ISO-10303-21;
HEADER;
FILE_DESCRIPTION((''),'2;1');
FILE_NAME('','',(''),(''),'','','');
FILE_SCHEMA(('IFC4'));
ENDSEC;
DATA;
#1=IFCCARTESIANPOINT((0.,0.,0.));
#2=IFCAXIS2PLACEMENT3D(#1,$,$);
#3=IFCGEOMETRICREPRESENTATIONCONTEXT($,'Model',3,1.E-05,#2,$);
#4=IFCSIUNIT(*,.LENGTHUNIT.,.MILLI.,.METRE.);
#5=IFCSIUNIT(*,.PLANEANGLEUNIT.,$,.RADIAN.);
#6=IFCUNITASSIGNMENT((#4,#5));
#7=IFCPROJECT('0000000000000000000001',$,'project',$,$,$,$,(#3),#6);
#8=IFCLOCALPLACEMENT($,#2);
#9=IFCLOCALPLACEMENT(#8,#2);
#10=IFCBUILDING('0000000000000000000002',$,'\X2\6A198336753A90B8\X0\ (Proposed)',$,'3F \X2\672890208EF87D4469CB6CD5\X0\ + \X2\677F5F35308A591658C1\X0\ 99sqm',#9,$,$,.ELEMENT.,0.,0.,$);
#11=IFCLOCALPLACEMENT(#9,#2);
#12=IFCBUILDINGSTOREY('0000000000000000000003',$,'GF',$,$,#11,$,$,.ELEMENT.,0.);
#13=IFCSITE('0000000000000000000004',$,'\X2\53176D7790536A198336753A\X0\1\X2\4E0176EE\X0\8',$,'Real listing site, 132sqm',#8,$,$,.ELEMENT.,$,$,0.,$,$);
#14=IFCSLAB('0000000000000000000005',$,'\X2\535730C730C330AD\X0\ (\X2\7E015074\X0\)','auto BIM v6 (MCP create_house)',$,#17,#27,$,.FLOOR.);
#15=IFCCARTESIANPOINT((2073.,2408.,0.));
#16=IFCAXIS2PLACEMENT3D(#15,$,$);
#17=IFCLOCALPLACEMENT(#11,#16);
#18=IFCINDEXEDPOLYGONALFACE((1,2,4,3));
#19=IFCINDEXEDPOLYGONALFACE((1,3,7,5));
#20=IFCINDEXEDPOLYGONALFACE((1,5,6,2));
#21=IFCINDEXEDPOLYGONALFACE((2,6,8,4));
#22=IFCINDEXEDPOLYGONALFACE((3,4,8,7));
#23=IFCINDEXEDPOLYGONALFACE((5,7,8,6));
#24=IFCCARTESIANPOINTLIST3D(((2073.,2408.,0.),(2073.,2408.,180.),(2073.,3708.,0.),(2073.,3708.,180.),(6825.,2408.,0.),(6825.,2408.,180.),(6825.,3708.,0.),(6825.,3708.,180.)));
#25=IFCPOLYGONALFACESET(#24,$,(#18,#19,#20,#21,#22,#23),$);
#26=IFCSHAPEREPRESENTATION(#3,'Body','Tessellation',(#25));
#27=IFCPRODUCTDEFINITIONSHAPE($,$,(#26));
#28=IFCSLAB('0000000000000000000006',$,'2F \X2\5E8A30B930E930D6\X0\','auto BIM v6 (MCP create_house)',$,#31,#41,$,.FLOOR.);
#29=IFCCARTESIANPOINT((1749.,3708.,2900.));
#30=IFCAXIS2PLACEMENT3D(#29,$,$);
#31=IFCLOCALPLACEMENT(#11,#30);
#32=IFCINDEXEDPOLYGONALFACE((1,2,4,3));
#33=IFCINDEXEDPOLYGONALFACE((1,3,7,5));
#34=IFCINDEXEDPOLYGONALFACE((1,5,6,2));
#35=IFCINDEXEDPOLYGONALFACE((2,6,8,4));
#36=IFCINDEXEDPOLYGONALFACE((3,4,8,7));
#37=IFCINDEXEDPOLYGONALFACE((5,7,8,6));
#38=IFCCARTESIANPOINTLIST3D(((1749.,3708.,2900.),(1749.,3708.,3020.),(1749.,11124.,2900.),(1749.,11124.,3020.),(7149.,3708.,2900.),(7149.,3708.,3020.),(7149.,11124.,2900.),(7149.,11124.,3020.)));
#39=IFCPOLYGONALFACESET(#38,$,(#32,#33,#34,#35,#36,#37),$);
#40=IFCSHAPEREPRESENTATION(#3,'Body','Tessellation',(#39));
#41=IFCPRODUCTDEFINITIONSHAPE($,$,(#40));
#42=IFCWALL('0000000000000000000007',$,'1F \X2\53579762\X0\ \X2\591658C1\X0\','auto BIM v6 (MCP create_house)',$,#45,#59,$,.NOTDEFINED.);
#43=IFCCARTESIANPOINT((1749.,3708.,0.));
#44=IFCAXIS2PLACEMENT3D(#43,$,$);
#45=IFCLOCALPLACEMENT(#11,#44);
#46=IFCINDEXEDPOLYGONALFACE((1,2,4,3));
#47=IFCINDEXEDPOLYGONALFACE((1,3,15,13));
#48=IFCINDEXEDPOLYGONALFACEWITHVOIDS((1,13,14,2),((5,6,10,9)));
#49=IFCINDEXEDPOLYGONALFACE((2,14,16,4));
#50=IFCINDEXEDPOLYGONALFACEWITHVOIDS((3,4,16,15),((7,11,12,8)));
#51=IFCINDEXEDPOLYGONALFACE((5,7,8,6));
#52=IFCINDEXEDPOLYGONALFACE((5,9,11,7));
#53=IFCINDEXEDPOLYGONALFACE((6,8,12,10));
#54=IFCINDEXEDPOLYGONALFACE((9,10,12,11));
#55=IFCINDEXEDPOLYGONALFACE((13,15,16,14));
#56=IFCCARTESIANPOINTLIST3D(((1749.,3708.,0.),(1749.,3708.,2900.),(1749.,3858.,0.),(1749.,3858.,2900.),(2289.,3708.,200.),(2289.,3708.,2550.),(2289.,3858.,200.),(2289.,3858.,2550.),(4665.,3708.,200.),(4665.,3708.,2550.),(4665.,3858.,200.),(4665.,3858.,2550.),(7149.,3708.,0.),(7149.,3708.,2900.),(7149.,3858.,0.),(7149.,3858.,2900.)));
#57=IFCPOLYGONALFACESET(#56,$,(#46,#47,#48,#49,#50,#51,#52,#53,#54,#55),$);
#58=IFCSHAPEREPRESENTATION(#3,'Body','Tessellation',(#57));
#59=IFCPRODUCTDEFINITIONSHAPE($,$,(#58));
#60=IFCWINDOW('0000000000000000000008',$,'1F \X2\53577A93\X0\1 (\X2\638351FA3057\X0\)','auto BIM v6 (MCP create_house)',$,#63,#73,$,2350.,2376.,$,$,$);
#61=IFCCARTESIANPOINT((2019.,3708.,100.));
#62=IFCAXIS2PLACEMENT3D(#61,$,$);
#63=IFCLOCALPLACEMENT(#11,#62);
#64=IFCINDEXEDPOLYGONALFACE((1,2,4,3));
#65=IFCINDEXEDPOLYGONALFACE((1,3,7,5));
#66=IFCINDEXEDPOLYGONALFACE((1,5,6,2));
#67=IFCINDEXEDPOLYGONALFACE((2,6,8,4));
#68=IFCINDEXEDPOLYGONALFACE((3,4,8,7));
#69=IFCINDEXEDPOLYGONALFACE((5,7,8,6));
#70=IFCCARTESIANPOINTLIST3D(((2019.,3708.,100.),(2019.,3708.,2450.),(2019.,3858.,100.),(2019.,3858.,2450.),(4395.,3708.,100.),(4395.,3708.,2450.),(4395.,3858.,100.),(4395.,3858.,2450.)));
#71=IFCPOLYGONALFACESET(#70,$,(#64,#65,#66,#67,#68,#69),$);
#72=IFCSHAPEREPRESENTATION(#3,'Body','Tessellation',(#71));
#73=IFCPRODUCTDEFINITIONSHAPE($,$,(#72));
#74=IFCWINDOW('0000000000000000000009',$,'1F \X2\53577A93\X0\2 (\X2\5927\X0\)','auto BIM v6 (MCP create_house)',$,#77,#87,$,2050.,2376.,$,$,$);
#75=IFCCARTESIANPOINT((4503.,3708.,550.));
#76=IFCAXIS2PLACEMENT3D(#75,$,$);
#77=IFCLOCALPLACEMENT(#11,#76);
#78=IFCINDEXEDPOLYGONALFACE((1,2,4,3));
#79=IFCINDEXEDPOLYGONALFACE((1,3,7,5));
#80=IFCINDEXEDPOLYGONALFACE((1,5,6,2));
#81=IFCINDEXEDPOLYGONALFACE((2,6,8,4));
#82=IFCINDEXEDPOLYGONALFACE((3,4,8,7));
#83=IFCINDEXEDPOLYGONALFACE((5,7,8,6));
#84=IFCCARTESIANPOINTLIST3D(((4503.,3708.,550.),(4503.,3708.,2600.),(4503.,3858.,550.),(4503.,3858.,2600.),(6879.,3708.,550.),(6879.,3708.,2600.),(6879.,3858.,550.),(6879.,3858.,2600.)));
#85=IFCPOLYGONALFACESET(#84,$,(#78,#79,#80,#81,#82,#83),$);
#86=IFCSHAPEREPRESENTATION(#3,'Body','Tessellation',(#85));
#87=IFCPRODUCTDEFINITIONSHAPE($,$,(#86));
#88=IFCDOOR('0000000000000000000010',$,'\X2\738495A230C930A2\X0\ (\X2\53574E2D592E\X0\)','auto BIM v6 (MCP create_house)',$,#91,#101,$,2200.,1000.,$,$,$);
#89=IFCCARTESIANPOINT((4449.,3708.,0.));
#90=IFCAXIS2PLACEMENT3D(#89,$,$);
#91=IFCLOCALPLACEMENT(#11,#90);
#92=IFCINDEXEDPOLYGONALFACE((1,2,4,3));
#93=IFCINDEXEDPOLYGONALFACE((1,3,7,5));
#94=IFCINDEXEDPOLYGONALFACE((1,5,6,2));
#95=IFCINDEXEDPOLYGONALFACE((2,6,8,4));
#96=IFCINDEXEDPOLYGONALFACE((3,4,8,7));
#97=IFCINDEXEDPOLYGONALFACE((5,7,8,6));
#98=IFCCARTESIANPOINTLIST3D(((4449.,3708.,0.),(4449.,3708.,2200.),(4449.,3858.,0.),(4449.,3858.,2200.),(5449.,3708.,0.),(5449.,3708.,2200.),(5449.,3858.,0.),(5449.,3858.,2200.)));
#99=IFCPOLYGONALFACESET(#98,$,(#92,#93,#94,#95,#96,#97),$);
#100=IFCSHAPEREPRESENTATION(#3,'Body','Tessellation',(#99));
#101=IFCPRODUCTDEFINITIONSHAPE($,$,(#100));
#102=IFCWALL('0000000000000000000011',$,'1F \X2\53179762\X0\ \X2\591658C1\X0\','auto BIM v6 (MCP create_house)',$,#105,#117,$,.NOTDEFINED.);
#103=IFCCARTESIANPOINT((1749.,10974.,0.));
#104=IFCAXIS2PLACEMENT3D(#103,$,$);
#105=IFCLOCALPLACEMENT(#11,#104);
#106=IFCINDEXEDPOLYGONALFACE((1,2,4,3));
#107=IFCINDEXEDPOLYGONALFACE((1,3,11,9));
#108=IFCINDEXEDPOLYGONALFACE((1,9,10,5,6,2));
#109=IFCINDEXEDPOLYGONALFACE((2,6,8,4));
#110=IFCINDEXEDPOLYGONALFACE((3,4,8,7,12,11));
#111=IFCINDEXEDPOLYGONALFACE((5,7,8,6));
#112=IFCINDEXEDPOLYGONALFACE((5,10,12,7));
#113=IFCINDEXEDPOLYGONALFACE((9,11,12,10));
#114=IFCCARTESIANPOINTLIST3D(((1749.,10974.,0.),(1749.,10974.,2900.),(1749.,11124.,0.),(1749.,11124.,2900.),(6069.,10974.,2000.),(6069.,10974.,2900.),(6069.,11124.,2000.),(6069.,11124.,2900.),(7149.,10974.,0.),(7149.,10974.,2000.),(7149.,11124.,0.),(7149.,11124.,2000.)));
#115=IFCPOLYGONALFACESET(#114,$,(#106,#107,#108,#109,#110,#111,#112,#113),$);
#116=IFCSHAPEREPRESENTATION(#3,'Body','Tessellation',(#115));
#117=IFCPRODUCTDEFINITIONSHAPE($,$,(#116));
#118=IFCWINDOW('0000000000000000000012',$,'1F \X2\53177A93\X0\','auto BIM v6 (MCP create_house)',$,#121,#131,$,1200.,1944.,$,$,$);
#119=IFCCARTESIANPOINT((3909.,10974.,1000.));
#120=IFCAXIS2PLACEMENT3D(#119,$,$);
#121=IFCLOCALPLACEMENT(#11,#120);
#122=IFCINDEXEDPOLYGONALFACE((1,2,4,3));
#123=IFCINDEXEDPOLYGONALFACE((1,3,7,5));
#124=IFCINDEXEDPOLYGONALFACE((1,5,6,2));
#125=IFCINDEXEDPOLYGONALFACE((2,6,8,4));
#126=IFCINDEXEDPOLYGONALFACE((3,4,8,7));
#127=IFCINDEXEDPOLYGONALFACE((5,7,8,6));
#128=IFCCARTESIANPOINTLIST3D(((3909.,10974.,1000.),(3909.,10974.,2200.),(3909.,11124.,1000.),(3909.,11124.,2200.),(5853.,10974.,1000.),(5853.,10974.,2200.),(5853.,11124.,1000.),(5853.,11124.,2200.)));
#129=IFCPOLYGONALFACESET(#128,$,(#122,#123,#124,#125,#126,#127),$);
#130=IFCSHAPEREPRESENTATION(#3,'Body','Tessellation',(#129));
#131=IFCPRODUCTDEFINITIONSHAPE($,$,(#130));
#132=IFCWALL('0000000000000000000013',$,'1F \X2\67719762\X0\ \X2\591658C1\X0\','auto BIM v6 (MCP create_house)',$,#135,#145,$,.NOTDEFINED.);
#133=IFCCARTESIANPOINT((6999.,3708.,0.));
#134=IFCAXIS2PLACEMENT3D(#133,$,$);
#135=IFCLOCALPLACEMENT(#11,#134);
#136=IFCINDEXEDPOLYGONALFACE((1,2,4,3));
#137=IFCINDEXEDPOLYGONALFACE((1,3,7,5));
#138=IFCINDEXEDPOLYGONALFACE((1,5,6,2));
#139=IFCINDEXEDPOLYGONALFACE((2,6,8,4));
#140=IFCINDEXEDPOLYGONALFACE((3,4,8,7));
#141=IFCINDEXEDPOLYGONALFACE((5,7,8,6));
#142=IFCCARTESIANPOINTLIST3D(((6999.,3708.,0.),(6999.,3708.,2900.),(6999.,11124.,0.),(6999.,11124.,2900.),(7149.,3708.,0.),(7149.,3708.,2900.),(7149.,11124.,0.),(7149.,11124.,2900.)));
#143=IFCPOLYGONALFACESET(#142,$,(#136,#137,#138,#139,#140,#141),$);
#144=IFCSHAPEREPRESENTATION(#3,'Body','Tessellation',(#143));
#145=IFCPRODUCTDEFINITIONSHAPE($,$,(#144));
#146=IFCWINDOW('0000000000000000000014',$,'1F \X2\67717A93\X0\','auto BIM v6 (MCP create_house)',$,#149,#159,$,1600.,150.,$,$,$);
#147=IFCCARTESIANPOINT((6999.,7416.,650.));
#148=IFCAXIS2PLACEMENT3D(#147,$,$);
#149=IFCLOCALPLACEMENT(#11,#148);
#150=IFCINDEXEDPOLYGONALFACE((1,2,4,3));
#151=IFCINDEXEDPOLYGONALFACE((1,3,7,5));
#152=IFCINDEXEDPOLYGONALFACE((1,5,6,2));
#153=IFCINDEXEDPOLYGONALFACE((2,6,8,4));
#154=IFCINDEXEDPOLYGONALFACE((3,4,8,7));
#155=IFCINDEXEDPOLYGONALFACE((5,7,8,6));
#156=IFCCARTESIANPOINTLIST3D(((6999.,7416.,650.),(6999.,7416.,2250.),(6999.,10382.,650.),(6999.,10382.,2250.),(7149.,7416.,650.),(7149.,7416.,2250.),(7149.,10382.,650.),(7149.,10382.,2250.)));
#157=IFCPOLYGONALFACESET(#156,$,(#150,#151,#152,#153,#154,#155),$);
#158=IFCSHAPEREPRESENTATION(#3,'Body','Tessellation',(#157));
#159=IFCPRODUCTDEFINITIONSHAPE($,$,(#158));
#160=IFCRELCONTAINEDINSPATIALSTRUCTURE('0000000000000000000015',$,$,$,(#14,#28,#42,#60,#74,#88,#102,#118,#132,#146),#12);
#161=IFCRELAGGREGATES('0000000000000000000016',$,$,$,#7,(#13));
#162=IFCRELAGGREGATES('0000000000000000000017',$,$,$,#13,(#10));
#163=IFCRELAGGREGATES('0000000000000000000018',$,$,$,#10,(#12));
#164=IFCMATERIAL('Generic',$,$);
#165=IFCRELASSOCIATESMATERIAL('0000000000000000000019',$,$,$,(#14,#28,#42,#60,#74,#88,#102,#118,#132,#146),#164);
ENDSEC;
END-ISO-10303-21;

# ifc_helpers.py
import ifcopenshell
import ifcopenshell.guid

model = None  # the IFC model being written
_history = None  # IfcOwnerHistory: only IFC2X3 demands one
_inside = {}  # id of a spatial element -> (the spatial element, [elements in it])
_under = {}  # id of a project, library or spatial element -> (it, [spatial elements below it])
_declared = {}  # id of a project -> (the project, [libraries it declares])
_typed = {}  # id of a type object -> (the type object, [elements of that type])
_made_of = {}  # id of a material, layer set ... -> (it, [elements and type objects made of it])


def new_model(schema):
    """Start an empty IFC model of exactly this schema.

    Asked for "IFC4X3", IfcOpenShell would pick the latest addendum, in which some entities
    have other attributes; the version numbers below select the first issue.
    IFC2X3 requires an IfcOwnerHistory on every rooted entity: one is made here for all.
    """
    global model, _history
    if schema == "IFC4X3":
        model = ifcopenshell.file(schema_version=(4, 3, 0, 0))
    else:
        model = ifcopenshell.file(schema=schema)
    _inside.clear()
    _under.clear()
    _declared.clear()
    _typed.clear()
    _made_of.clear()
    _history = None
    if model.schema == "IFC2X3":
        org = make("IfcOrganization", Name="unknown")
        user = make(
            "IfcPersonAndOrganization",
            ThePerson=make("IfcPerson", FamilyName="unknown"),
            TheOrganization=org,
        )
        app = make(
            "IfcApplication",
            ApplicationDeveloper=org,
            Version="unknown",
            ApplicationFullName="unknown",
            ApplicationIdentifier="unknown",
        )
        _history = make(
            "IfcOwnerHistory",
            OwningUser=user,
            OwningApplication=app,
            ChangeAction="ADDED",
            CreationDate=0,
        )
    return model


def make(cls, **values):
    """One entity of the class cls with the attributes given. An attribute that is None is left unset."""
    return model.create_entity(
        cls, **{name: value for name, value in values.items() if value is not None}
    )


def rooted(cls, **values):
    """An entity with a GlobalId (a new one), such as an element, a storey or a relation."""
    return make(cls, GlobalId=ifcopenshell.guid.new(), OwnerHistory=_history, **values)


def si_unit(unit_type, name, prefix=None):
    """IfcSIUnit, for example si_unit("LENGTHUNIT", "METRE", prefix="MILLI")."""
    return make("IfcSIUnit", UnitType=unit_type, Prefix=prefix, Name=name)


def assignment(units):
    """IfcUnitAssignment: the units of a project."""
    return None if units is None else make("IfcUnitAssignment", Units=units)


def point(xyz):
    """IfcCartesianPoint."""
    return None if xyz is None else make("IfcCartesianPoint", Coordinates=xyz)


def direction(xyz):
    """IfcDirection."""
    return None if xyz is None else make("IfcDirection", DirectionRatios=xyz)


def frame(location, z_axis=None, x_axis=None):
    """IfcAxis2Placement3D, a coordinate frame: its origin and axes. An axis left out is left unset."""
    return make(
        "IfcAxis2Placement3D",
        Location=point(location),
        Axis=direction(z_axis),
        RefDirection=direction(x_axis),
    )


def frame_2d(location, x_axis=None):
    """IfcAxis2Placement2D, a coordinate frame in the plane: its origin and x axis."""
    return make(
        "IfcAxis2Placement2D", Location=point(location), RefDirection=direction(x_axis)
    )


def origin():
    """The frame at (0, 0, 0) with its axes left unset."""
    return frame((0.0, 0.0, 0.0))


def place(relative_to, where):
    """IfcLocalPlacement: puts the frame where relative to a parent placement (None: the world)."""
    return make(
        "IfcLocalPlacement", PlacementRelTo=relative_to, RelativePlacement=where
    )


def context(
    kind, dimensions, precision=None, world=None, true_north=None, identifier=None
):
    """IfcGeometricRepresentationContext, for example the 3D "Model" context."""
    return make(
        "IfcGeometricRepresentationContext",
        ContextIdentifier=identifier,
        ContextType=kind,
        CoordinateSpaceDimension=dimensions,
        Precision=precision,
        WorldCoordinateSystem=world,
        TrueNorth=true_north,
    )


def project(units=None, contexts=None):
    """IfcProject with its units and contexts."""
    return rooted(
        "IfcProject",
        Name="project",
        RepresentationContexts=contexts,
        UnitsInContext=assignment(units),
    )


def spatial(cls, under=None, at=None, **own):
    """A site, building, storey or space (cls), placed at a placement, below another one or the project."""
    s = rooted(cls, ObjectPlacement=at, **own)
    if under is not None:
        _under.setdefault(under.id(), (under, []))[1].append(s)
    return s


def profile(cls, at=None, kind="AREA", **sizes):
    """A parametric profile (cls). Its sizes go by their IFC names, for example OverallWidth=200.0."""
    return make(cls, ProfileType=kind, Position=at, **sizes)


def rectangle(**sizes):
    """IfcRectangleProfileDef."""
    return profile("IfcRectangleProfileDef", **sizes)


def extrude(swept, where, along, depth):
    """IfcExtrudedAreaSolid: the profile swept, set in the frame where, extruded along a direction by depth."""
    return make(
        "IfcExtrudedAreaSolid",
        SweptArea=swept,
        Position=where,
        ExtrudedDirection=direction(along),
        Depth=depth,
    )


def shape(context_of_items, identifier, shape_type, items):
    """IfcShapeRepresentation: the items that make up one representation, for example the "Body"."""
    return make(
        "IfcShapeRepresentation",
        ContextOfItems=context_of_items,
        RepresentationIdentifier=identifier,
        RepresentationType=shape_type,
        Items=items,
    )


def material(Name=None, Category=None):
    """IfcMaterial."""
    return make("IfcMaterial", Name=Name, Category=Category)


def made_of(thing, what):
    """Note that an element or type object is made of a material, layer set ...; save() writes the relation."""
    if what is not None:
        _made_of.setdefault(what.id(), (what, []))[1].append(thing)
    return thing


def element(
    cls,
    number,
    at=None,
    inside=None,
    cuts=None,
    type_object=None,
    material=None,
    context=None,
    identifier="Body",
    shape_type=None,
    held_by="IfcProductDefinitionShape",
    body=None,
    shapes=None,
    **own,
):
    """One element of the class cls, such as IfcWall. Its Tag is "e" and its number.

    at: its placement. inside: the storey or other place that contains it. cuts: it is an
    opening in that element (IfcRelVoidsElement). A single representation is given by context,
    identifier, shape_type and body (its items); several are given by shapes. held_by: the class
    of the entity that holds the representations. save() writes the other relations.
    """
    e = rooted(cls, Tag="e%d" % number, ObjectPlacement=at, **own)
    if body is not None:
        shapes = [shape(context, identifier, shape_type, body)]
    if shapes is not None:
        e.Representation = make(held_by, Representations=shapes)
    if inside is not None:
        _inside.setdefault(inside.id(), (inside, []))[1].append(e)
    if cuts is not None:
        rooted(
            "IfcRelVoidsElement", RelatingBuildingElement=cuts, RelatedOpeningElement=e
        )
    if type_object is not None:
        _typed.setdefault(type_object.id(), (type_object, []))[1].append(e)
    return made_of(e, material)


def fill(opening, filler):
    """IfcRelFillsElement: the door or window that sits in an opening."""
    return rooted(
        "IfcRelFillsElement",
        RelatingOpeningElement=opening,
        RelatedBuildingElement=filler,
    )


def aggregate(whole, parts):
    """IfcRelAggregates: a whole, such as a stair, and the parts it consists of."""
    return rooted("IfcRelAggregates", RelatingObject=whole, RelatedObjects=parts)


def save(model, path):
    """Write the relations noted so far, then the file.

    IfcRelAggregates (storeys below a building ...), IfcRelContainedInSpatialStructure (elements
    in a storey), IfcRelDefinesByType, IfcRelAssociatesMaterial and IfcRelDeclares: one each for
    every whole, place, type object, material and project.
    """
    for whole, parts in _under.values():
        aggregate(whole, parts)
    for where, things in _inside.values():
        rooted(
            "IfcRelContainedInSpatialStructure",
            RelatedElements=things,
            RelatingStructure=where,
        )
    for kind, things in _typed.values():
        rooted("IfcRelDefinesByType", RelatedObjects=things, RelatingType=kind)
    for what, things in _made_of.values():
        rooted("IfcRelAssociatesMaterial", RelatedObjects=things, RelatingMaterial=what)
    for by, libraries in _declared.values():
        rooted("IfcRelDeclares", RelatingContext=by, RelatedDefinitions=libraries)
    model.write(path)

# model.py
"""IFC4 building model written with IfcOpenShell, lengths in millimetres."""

from ifc_helpers import new_model, si_unit, frame, frame_2d, origin, place, context, project, spatial, rectangle, extrude, material, element, fill, save


model = new_model("IFC4")

# Units and contexts
model_context = context("Model", 3, precision=1e-05, world=origin())
ifc_project = project(units=[si_unit("LENGTHUNIT", "METRE", prefix="MILLI"), si_unit("PLANEANGLEUNIT", "RADIAN")], contexts=[model_context])

# Site, building, storey
site_placement = place(None, origin())
site = spatial("IfcSite", under=ifc_project, at=site_placement, Name="北海道標茶町1丁目8", ObjectType="Real listing site, 132sqm", CompositionType="ELEMENT", RefElevation=0.0)
building_placement = place(site_placement, origin())
building = spatial("IfcBuilding", under=site, at=building_placement, Name="標茶町邸 (Proposed)", ObjectType="3F 木造軸組構法 + 板張り外壁 99sqm", CompositionType="ELEMENT", ElevationOfRefHeight=0.0, ElevationOfTerrain=0.0)
storey_placement = place(building_placement, origin())
storey = spatial("IfcBuildingStorey", under=building, at=storey_placement, Name="GF", CompositionType="ELEMENT", Elevation=0.0)

# Slabs
ifc_material = material(Name="Generic")
slab_1_placement = place(storey_placement, frame((2073.0, 2408.0, 0.0)))
element("IfcSlab", 1, at=slab_1_placement, inside=storey, material=ifc_material, Name="南デッキ (縁側)", Description="auto BIM v6 (MCP create_house)", PredefinedType="FLOOR", context=model_context, shape_type="SweptSolid", body=[
    extrude(rectangle(XDim=4752.0, YDim=1300.0, at=frame_2d((2376.0, 650.0))), frame((2073.0, 2408.0, 0.0)), (0.0, 0.0, 1.0), 180.0),
])
slab_2_placement = place(storey_placement, frame((1749.0, 3708.0, 2900.0)))
element("IfcSlab", 2, at=slab_2_placement, inside=storey, material=ifc_material, Name="2F 床スラブ", Description="auto BIM v6 (MCP create_house)", PredefinedType="FLOOR", context=model_context, shape_type="SweptSolid", body=[
    extrude(rectangle(XDim=5400.0, YDim=7416.0, at=frame_2d((2700.0, 3708.0))), frame((1749.0, 3708.0, 2900.0)), (0.0, 0.0, 1.0), 120.0),
])

# Wall, openings, windows, door
wall_1_placement = place(storey_placement, frame((1749.0, 3708.0, 0.0)))
wall_1 = element("IfcWall", 3, at=wall_1_placement, inside=storey, material=ifc_material, Name="1F 南面 外壁", Description="auto BIM v6 (MCP create_house)", PredefinedType="NOTDEFINED", context=model_context, shape_type="SweptSolid", body=[
    extrude(rectangle(XDim=5400.0, YDim=150.0, at=frame_2d((2700.0, 75.0))), frame((1749.0, 3708.0, 0.0)), (0.0, 0.0, 1.0), 2900.0),
])
opening_1_placement = place(storey_placement, frame((2019.0, 3708.0, 100.0)))
opening_1 = element("IfcOpeningElement", 4, at=opening_1_placement, cuts=wall_1, PredefinedType="NOTDEFINED", context=model_context, shape_type="SweptSolid", body=[
    extrude(rectangle(XDim=2376.0, YDim=150.0, at=frame_2d((1188.0, 75.0))), frame((2019.0, 3708.0, 100.0)), (0.0, 0.0, 1.0), 2350.0),
])
opening_2_placement = place(storey_placement, frame((4503.0, 3708.0, 550.0)))
opening_2 = element("IfcOpeningElement", 5, at=opening_2_placement, cuts=wall_1, PredefinedType="NOTDEFINED", context=model_context, shape_type="SweptSolid", body=[
    extrude(rectangle(XDim=2376.0, YDim=150.0, at=frame_2d((1188.0, 75.0))), frame((4503.0, 3708.0, 550.0)), (0.0, 0.0, 1.0), 2050.0),
])
opening_3_placement = place(storey_placement, frame((4449.0, 3708.0, 0.0)))
opening_3 = element("IfcOpeningElement", 6, at=opening_3_placement, cuts=wall_1, PredefinedType="NOTDEFINED", context=model_context, shape_type="SweptSolid", body=[
    extrude(rectangle(XDim=1000.0, YDim=150.0, at=frame_2d((500.0, 75.0))), frame((4449.0, 3708.0, 0.0)), (0.0, 0.0, 1.0), 2200.0),
])
window_1_placement = place(storey_placement, frame((2019.0, 3708.0, 100.0)))
window_1 = element("IfcWindow", 7, at=window_1_placement, inside=storey, material=ifc_material, Name="1F 南窓1 (掃出し)", Description="auto BIM v6 (MCP create_house)", OverallHeight=2350.0, OverallWidth=2376.0, context=model_context, shape_type="SweptSolid", body=[
    extrude(rectangle(XDim=2376.0, YDim=150.0, at=frame_2d((1188.0, 75.0))), frame((2019.0, 3708.0, 100.0)), (0.0, 0.0, 1.0), 2350.0),
])
fill(opening_1, window_1)
window_2_placement = place(storey_placement, frame((4503.0, 3708.0, 550.0)))
window_2 = element("IfcWindow", 8, at=window_2_placement, inside=storey, material=ifc_material, Name="1F 南窓2 (大)", Description="auto BIM v6 (MCP create_house)", OverallHeight=2050.0, OverallWidth=2376.0, context=model_context, shape_type="SweptSolid", body=[
    extrude(rectangle(XDim=2376.0, YDim=150.0, at=frame_2d((1188.0, 75.0))), frame((4503.0, 3708.0, 550.0)), (0.0, 0.0, 1.0), 2050.0),
])
fill(opening_2, window_2)
door_placement = place(storey_placement, frame((4449.0, 3708.0, 0.0)))
door = element("IfcDoor", 9, at=door_placement, inside=storey, material=ifc_material, Name="玄関ドア (南中央)", Description="auto BIM v6 (MCP create_house)", OverallHeight=2200.0, OverallWidth=1000.0, context=model_context, shape_type="SweptSolid", body=[
    extrude(rectangle(XDim=1000.0, YDim=150.0, at=frame_2d((500.0, 75.0))), frame((4449.0, 3708.0, 0.0)), (0.0, 0.0, 1.0), 2200.0),
])
fill(opening_3, door)

# Walls, openings, windows
wall_2_placement = place(storey_placement, frame((1749.0, 10974.0, 0.0)))
wall_2 = element("IfcWall", 10, at=wall_2_placement, inside=storey, material=ifc_material, Name="1F 北面 外壁", Description="auto BIM v6 (MCP create_house)", PredefinedType="NOTDEFINED", context=model_context, shape_type="SweptSolid", body=[
    extrude(rectangle(XDim=5400.0, YDim=150.0, at=frame_2d((2700.0, 75.0))), frame((1749.0, 10974.0, 0.0)), (0.0, 0.0, 1.0), 2900.0),
])
opening_4_placement = place(storey_placement, frame((3909.0, 10974.0, 1000.0)))
opening_4 = element("IfcOpeningElement", 11, at=opening_4_placement, cuts=wall_2, PredefinedType="NOTDEFINED", context=model_context, shape_type="SweptSolid", body=[
    extrude(rectangle(XDim=1944.0, YDim=150.0, at=frame_2d((972.0, 75.0))), frame((3909.0, 10974.0, 1000.0)), (0.0, 0.0, 1.0), 1200.0),
])
window_3_placement = place(storey_placement, frame((3909.0, 10974.0, 1000.0)))
window_3 = element("IfcWindow", 12, at=window_3_placement, inside=storey, material=ifc_material, Name="1F 北窓", Description="auto BIM v6 (MCP create_house)", OverallHeight=1200.0, OverallWidth=1944.0, context=model_context, shape_type="SweptSolid", body=[
    extrude(rectangle(XDim=1944.0, YDim=150.0, at=frame_2d((972.0, 75.0))), frame((3909.0, 10974.0, 1000.0)), (0.0, 0.0, 1.0), 1200.0),
])
fill(opening_4, window_3)
wall_3_placement = place(storey_placement, frame((6999.0, 3708.0, 0.0)))
wall_3 = element("IfcWall", 13, at=wall_3_placement, inside=storey, material=ifc_material, Name="1F 東面 外壁", Description="auto BIM v6 (MCP create_house)", PredefinedType="NOTDEFINED", context=model_context, shape_type="SweptSolid", body=[
    extrude(rectangle(XDim=150.0, YDim=7416.0, at=frame_2d((75.0, 3708.0))), frame((6999.0, 3708.0, 0.0)), (0.0, 0.0, 1.0), 2900.0),
])
opening_5_placement = place(storey_placement, frame((6999.0, 7416.0, 650.0)))
opening_5 = element("IfcOpeningElement", 14, at=opening_5_placement, cuts=wall_3, PredefinedType="NOTDEFINED", context=model_context, shape_type="SweptSolid", body=[
    extrude(rectangle(XDim=150.0, YDim=2966.0, at=frame_2d((75.0, 1483.0))), frame((6999.0, 7416.0, 650.0)), (0.0, 0.0, 1.0), 1600.0),
])
window_4_placement = place(storey_placement, frame((6999.0, 7416.0, 650.0)))
window_4 = element("IfcWindow", 15, at=window_4_placement, inside=storey, material=ifc_material, Name="1F 東窓", Description="auto BIM v6 (MCP create_house)", OverallHeight=1600.0, OverallWidth=150.0, context=model_context, shape_type="SweptSolid", body=[
    extrude(rectangle(XDim=150.0, YDim=2966.0, at=frame_2d((75.0, 1483.0))), frame((6999.0, 7416.0, 650.0)), (0.0, 0.0, 1.0), 1600.0),
])
fill(opening_5, window_4)

save(model, "model.ifc")
